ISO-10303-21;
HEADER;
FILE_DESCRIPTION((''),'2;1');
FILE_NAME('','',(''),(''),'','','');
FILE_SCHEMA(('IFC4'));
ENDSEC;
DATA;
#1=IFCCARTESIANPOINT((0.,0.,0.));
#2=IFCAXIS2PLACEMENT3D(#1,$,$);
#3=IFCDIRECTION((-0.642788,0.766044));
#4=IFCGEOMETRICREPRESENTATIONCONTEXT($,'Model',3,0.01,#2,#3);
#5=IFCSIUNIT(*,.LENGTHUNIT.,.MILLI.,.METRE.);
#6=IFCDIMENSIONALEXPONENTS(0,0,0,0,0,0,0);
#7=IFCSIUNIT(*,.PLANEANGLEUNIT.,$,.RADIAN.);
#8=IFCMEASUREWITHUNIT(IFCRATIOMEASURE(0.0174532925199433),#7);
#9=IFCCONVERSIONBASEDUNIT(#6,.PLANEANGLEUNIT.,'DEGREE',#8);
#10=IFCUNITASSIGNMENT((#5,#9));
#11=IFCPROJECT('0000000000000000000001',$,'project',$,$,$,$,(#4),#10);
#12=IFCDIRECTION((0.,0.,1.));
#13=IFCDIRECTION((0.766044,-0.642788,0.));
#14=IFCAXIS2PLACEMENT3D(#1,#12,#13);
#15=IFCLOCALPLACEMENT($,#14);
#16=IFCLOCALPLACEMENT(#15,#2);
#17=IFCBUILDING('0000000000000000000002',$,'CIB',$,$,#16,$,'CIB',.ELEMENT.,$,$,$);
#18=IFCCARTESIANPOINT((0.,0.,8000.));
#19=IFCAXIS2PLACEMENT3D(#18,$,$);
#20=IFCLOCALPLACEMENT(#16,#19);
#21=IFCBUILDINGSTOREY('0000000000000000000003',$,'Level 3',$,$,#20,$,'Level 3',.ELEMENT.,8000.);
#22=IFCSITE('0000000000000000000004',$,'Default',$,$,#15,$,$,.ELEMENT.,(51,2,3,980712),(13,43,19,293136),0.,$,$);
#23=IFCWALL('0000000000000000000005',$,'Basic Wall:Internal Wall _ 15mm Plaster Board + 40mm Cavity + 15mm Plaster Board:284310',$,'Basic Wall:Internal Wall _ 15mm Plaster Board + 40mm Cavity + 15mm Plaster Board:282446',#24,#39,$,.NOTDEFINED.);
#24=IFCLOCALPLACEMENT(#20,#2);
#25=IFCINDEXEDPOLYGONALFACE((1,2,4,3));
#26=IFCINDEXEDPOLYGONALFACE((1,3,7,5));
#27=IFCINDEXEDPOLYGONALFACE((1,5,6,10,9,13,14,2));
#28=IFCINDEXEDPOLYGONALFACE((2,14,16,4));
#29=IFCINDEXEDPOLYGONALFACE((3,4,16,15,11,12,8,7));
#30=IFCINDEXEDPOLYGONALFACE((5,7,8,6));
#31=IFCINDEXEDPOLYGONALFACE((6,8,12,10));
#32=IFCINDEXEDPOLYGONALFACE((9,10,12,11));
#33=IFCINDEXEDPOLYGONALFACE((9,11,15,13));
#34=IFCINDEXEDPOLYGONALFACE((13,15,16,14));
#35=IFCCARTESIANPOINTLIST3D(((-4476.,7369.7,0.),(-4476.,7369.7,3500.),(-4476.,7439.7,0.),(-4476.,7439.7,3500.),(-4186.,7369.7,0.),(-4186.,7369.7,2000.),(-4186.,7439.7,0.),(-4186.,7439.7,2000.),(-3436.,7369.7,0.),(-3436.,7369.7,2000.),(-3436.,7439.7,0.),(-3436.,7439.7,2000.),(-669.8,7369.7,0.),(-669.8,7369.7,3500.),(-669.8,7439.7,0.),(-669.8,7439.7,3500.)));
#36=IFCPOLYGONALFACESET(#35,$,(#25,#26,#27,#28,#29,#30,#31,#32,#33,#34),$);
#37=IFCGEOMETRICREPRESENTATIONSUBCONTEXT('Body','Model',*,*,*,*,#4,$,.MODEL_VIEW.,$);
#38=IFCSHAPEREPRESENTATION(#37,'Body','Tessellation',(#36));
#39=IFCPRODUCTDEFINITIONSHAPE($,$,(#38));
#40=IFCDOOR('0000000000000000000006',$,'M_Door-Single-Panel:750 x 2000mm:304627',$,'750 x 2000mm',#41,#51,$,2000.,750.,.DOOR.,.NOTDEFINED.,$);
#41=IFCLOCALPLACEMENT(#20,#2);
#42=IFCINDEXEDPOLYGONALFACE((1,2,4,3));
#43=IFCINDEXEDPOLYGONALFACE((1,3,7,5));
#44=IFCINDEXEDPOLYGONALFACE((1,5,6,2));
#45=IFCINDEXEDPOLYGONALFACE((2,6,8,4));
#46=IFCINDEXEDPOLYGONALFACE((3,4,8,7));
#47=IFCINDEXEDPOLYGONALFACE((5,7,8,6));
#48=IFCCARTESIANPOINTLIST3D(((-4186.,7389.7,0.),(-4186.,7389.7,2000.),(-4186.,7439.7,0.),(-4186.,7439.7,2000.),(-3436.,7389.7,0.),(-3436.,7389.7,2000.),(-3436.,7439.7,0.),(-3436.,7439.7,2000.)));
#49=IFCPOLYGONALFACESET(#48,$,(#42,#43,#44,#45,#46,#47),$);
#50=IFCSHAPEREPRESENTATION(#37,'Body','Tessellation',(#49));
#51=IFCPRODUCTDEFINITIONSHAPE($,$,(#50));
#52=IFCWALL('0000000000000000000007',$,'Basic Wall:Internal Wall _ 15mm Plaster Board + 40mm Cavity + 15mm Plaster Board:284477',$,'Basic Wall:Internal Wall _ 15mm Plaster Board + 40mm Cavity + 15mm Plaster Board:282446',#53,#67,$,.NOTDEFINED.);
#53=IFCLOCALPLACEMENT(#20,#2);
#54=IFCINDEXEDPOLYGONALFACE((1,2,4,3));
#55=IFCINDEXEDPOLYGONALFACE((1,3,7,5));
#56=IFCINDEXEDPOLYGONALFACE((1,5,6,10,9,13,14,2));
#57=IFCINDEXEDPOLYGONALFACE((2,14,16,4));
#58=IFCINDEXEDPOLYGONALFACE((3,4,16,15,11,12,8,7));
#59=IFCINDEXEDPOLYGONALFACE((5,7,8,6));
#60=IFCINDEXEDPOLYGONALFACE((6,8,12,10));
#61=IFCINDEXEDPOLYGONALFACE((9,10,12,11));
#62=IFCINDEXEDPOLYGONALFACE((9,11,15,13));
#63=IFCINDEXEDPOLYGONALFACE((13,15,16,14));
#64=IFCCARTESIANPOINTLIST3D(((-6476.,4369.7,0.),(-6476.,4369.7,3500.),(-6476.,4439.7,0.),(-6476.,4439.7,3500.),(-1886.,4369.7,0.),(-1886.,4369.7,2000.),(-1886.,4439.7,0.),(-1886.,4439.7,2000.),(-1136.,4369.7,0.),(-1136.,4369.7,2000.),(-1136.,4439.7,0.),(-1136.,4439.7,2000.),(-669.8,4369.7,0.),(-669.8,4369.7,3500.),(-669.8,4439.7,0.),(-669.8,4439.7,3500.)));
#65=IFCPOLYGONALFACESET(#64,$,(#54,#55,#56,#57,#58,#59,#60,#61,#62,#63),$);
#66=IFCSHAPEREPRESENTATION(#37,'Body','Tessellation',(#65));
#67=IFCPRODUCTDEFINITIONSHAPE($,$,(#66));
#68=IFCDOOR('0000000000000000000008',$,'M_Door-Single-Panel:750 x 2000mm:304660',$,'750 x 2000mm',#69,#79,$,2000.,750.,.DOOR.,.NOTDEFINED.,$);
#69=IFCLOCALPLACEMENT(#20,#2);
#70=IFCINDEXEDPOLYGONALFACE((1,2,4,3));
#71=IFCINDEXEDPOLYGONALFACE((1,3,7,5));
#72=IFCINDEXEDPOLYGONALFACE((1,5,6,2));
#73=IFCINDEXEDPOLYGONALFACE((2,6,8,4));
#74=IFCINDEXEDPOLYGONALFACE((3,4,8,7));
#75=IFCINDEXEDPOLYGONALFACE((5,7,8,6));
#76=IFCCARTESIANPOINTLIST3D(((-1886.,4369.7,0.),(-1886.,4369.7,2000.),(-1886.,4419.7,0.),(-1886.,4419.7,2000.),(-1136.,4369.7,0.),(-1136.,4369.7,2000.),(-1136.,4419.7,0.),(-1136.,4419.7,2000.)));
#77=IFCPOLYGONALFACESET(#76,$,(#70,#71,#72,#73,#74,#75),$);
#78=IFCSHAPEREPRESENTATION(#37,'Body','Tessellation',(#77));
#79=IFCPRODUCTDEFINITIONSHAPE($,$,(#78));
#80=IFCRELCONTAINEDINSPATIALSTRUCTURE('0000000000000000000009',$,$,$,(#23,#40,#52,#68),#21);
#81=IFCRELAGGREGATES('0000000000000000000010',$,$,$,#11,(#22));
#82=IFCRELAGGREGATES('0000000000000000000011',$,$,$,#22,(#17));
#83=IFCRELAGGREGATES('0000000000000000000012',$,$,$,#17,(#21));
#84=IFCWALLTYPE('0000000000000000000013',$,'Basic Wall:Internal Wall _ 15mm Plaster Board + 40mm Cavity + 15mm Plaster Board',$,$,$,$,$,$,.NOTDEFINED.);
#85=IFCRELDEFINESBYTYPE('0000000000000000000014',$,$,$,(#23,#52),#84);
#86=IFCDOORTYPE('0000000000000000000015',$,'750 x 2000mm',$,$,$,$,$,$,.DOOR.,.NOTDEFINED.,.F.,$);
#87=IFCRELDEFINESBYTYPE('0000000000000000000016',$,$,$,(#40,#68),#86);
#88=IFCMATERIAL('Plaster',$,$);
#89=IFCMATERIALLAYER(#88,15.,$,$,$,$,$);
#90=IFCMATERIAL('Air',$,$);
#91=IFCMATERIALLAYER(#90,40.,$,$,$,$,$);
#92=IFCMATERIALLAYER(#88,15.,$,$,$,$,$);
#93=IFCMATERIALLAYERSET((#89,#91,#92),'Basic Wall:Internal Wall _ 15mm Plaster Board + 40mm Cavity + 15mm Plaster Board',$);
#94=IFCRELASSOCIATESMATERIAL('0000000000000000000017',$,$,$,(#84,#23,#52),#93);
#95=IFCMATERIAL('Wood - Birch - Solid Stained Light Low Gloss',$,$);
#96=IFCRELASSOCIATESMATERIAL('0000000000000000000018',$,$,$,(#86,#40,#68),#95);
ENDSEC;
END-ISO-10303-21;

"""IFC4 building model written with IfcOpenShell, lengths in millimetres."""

from ifc_helpers import new_model, entity, si_unit, converted_unit, direction, frame, frame_2d, origin, origin_2d_with_axis, place, context, subcontext, project, spatial, rectangle, extrude, source, transform, mapped, material, layer, layer_set, layer_usage, type_object, type_shapes, element, fill, save


model = new_model("IFC4")

# Units and contexts
model_context = context("Model", 3, precision=0.01, world=origin(), true_north=direction((-0.642788, 0.766044)))
body_context = subcontext(model_context, "Body", "Model", "MODEL_VIEW")
ifc_project = project(units=[si_unit("LENGTHUNIT", "METRE", prefix="MILLI"), converted_unit("PLANEANGLEUNIT", "DEGREE", entity("IfcRatioMeasure", 0.0174532925199433), si_unit("PLANEANGLEUNIT", "RADIAN"), dimensions=[0, 0, 0, 0, 0, 0, 0])], contexts=[model_context])

# Site, building, storey
site_placement = place(None, frame((0.0, 0.0, 0.0), z_axis=(0.0, 0.0, 1.0), x_axis=(0.766044, -0.642788, 0.0)))
site = spatial("IfcSite", under=ifc_project, at=site_placement, Name="Default", CompositionType="ELEMENT", RefLatitude=(51, 2, 3, 980712), RefLongitude=(13, 43, 19, 293136), RefElevation=0.0)
building_placement = place(site_placement, origin())
building = spatial("IfcBuilding", under=site, at=building_placement, Name="CIB", LongName="CIB", CompositionType="ELEMENT")
storey_placement = place(building_placement, frame((0.0, 0.0, 8000.0)))
storey = spatial("IfcBuildingStorey", under=building, at=storey_placement, Name="Level 3", LongName="Level 3", CompositionType="ELEMENT", Elevation=8000.0)

# Shared definitions
ifc_material_1 = material(Name="Plaster")
ifc_layer_1 = layer(ifc_material_1, 15.0)
ifc_material_2 = material(Name="Air")
ifc_layer_2 = layer(ifc_material_2, 40.0)
ifc_layer_3 = layer(ifc_material_1, 15.0)
ifc_layer_set_1 = layer_set([ifc_layer_1, ifc_layer_2, ifc_layer_3], Name="Basic Wall:Internal Wall _ 15mm Plaster Board + 40mm Cavity + 15mm Plaster Board")
wall_type_1 = type_object("IfcWallType", Name="Basic Wall:Internal Wall _ 15mm Plaster Board + 40mm Cavity + 15mm Plaster Board", PredefinedType="NOTDEFINED", material=ifc_layer_set_1)

# Walls, openings, doors
ifc_layer_usage_1 = layer_usage(ifc_layer_set_1, "AXIS2", "NEGATIVE", 35.0)
wall_1_placement = place(storey_placement, frame((-4476.0, 7404.7, 0.0)))
wall_1 = element("IfcWall", 1, at=wall_1_placement, inside=storey, type_object=wall_type_1, material=ifc_layer_usage_1, Name="Basic Wall:Internal Wall _ 15mm Plaster Board + 40mm Cavity + 15mm Plaster Board:284310", ObjectType="Basic Wall:Internal Wall _ 15mm Plaster Board + 40mm Cavity + 15mm Plaster Board:282446", PredefinedType="NOTDEFINED", context=body_context, shape_type="SweptSolid", body=[
    extrude(rectangle(XDim=3806.3, YDim=70.0, at=frame_2d((1903.1, 0.0), x_axis=(-1.0, 0.0))), origin(), (0.0, 0.0, 1.0), 3500.0),
])
opening_1_placement = place(wall_1_placement, frame((290.0, -35.0, 0.0)))
opening_1 = element("IfcOpeningElement", 2, at=opening_1_placement, cuts=wall_1, ObjectType="Opening", PredefinedType="OPENING", context=body_context, shape_type="SweptSolid", body=[
    extrude(rectangle(XDim=750.0, YDim=2000.0, at=frame_2d((1000.0, 375.0), x_axis=(0.0, -1.0))), frame((0.0, 0.0, 0.0), z_axis=(0.0, 1.0, 0.0), x_axis=(0.0, 0.0, 1.0)), (0.0, 0.0, 1.0), 70.0),
])
ifc_material_3 = material(Name="Wood - Birch - Solid Stained Light Low Gloss")
door_type = type_object("IfcDoorType", Name="750 x 2000mm", OperationType="NOTDEFINED", ParameterTakesPrecedence=False, PredefinedType="DOOR", material=ifc_material_3)
shared_shape_1 = source(origin(), body_context, "Body", "SweptSolid", [
    extrude(rectangle(XDim=750.0, YDim=50.0, at=origin_2d_with_axis()), frame((375.0, 45.0, 0.0)), (0.0, 0.0, 1.0), 2000.0),
])
type_shapes(door_type, [shared_shape_1])
door_1_placement = place(opening_1_placement, origin())
door_1 = element("IfcDoor", 3, at=door_1_placement, inside=storey, type_object=door_type, material=ifc_material_3, Name="M_Door-Single-Panel:750 x 2000mm:304627", ObjectType="750 x 2000mm", OperationType="NOTDEFINED", OverallHeight=2000.0, OverallWidth=750.0, PredefinedType="DOOR", context=body_context, shape_type="MappedRepresentation", body=[
    mapped(shared_shape_1, transform((0.0, 0.0, 0.0), scale=1.0)),
])
fill(opening_1, door_1)
ifc_layer_usage_2 = layer_usage(ifc_layer_set_1, "AXIS2", "NEGATIVE", 35.0)
wall_2_placement = place(storey_placement, frame((-6476.0, 4404.7, 0.0)))
wall_2 = element("IfcWall", 4, at=wall_2_placement, inside=storey, type_object=wall_type_1, material=ifc_layer_usage_2, Name="Basic Wall:Internal Wall _ 15mm Plaster Board + 40mm Cavity + 15mm Plaster Board:284477", ObjectType="Basic Wall:Internal Wall _ 15mm Plaster Board + 40mm Cavity + 15mm Plaster Board:282446", PredefinedType="NOTDEFINED", context=body_context, shape_type="SweptSolid", body=[
    extrude(rectangle(XDim=5806.2, YDim=70.0, at=frame_2d((2903.1, 0.0), x_axis=(-1.0, 0.0))), origin(), (0.0, 0.0, 1.0), 3500.0),
])
opening_2_placement = place(wall_2_placement, frame((5340.0, 35.0, 0.0)))
opening_2 = element("IfcOpeningElement", 5, at=opening_2_placement, cuts=wall_2, ObjectType="Opening", PredefinedType="OPENING", context=body_context, shape_type="SweptSolid", body=[
    extrude(rectangle(XDim=750.0, YDim=2000.0, at=frame_2d((1000.0, 375.0), x_axis=(0.0, -1.0))), frame((0.0, 0.0, 0.0), z_axis=(0.0, -1.0, 0.0), x_axis=(0.0, 0.0, 1.0)), (0.0, 0.0, 1.0), 70.0),
])
door_2_placement = place(opening_2_placement, frame((0.0, 0.0, 0.0), z_axis=(0.0, 0.0, 1.0), x_axis=(-1.0, 0.0, 0.0)))
door_2 = element("IfcDoor", 6, at=door_2_placement, inside=storey, type_object=door_type, material=ifc_material_3, Name="M_Door-Single-Panel:750 x 2000mm:304660", ObjectType="750 x 2000mm", OperationType="NOTDEFINED", OverallHeight=2000.0, OverallWidth=750.0, PredefinedType="DOOR", context=body_context, shape_type="MappedRepresentation", body=[
    mapped(shared_shape_1, transform((0.0, 0.0, 0.0), scale=1.0)),
])
fill(opening_2, door_2)

save(model, "model.ifc")
